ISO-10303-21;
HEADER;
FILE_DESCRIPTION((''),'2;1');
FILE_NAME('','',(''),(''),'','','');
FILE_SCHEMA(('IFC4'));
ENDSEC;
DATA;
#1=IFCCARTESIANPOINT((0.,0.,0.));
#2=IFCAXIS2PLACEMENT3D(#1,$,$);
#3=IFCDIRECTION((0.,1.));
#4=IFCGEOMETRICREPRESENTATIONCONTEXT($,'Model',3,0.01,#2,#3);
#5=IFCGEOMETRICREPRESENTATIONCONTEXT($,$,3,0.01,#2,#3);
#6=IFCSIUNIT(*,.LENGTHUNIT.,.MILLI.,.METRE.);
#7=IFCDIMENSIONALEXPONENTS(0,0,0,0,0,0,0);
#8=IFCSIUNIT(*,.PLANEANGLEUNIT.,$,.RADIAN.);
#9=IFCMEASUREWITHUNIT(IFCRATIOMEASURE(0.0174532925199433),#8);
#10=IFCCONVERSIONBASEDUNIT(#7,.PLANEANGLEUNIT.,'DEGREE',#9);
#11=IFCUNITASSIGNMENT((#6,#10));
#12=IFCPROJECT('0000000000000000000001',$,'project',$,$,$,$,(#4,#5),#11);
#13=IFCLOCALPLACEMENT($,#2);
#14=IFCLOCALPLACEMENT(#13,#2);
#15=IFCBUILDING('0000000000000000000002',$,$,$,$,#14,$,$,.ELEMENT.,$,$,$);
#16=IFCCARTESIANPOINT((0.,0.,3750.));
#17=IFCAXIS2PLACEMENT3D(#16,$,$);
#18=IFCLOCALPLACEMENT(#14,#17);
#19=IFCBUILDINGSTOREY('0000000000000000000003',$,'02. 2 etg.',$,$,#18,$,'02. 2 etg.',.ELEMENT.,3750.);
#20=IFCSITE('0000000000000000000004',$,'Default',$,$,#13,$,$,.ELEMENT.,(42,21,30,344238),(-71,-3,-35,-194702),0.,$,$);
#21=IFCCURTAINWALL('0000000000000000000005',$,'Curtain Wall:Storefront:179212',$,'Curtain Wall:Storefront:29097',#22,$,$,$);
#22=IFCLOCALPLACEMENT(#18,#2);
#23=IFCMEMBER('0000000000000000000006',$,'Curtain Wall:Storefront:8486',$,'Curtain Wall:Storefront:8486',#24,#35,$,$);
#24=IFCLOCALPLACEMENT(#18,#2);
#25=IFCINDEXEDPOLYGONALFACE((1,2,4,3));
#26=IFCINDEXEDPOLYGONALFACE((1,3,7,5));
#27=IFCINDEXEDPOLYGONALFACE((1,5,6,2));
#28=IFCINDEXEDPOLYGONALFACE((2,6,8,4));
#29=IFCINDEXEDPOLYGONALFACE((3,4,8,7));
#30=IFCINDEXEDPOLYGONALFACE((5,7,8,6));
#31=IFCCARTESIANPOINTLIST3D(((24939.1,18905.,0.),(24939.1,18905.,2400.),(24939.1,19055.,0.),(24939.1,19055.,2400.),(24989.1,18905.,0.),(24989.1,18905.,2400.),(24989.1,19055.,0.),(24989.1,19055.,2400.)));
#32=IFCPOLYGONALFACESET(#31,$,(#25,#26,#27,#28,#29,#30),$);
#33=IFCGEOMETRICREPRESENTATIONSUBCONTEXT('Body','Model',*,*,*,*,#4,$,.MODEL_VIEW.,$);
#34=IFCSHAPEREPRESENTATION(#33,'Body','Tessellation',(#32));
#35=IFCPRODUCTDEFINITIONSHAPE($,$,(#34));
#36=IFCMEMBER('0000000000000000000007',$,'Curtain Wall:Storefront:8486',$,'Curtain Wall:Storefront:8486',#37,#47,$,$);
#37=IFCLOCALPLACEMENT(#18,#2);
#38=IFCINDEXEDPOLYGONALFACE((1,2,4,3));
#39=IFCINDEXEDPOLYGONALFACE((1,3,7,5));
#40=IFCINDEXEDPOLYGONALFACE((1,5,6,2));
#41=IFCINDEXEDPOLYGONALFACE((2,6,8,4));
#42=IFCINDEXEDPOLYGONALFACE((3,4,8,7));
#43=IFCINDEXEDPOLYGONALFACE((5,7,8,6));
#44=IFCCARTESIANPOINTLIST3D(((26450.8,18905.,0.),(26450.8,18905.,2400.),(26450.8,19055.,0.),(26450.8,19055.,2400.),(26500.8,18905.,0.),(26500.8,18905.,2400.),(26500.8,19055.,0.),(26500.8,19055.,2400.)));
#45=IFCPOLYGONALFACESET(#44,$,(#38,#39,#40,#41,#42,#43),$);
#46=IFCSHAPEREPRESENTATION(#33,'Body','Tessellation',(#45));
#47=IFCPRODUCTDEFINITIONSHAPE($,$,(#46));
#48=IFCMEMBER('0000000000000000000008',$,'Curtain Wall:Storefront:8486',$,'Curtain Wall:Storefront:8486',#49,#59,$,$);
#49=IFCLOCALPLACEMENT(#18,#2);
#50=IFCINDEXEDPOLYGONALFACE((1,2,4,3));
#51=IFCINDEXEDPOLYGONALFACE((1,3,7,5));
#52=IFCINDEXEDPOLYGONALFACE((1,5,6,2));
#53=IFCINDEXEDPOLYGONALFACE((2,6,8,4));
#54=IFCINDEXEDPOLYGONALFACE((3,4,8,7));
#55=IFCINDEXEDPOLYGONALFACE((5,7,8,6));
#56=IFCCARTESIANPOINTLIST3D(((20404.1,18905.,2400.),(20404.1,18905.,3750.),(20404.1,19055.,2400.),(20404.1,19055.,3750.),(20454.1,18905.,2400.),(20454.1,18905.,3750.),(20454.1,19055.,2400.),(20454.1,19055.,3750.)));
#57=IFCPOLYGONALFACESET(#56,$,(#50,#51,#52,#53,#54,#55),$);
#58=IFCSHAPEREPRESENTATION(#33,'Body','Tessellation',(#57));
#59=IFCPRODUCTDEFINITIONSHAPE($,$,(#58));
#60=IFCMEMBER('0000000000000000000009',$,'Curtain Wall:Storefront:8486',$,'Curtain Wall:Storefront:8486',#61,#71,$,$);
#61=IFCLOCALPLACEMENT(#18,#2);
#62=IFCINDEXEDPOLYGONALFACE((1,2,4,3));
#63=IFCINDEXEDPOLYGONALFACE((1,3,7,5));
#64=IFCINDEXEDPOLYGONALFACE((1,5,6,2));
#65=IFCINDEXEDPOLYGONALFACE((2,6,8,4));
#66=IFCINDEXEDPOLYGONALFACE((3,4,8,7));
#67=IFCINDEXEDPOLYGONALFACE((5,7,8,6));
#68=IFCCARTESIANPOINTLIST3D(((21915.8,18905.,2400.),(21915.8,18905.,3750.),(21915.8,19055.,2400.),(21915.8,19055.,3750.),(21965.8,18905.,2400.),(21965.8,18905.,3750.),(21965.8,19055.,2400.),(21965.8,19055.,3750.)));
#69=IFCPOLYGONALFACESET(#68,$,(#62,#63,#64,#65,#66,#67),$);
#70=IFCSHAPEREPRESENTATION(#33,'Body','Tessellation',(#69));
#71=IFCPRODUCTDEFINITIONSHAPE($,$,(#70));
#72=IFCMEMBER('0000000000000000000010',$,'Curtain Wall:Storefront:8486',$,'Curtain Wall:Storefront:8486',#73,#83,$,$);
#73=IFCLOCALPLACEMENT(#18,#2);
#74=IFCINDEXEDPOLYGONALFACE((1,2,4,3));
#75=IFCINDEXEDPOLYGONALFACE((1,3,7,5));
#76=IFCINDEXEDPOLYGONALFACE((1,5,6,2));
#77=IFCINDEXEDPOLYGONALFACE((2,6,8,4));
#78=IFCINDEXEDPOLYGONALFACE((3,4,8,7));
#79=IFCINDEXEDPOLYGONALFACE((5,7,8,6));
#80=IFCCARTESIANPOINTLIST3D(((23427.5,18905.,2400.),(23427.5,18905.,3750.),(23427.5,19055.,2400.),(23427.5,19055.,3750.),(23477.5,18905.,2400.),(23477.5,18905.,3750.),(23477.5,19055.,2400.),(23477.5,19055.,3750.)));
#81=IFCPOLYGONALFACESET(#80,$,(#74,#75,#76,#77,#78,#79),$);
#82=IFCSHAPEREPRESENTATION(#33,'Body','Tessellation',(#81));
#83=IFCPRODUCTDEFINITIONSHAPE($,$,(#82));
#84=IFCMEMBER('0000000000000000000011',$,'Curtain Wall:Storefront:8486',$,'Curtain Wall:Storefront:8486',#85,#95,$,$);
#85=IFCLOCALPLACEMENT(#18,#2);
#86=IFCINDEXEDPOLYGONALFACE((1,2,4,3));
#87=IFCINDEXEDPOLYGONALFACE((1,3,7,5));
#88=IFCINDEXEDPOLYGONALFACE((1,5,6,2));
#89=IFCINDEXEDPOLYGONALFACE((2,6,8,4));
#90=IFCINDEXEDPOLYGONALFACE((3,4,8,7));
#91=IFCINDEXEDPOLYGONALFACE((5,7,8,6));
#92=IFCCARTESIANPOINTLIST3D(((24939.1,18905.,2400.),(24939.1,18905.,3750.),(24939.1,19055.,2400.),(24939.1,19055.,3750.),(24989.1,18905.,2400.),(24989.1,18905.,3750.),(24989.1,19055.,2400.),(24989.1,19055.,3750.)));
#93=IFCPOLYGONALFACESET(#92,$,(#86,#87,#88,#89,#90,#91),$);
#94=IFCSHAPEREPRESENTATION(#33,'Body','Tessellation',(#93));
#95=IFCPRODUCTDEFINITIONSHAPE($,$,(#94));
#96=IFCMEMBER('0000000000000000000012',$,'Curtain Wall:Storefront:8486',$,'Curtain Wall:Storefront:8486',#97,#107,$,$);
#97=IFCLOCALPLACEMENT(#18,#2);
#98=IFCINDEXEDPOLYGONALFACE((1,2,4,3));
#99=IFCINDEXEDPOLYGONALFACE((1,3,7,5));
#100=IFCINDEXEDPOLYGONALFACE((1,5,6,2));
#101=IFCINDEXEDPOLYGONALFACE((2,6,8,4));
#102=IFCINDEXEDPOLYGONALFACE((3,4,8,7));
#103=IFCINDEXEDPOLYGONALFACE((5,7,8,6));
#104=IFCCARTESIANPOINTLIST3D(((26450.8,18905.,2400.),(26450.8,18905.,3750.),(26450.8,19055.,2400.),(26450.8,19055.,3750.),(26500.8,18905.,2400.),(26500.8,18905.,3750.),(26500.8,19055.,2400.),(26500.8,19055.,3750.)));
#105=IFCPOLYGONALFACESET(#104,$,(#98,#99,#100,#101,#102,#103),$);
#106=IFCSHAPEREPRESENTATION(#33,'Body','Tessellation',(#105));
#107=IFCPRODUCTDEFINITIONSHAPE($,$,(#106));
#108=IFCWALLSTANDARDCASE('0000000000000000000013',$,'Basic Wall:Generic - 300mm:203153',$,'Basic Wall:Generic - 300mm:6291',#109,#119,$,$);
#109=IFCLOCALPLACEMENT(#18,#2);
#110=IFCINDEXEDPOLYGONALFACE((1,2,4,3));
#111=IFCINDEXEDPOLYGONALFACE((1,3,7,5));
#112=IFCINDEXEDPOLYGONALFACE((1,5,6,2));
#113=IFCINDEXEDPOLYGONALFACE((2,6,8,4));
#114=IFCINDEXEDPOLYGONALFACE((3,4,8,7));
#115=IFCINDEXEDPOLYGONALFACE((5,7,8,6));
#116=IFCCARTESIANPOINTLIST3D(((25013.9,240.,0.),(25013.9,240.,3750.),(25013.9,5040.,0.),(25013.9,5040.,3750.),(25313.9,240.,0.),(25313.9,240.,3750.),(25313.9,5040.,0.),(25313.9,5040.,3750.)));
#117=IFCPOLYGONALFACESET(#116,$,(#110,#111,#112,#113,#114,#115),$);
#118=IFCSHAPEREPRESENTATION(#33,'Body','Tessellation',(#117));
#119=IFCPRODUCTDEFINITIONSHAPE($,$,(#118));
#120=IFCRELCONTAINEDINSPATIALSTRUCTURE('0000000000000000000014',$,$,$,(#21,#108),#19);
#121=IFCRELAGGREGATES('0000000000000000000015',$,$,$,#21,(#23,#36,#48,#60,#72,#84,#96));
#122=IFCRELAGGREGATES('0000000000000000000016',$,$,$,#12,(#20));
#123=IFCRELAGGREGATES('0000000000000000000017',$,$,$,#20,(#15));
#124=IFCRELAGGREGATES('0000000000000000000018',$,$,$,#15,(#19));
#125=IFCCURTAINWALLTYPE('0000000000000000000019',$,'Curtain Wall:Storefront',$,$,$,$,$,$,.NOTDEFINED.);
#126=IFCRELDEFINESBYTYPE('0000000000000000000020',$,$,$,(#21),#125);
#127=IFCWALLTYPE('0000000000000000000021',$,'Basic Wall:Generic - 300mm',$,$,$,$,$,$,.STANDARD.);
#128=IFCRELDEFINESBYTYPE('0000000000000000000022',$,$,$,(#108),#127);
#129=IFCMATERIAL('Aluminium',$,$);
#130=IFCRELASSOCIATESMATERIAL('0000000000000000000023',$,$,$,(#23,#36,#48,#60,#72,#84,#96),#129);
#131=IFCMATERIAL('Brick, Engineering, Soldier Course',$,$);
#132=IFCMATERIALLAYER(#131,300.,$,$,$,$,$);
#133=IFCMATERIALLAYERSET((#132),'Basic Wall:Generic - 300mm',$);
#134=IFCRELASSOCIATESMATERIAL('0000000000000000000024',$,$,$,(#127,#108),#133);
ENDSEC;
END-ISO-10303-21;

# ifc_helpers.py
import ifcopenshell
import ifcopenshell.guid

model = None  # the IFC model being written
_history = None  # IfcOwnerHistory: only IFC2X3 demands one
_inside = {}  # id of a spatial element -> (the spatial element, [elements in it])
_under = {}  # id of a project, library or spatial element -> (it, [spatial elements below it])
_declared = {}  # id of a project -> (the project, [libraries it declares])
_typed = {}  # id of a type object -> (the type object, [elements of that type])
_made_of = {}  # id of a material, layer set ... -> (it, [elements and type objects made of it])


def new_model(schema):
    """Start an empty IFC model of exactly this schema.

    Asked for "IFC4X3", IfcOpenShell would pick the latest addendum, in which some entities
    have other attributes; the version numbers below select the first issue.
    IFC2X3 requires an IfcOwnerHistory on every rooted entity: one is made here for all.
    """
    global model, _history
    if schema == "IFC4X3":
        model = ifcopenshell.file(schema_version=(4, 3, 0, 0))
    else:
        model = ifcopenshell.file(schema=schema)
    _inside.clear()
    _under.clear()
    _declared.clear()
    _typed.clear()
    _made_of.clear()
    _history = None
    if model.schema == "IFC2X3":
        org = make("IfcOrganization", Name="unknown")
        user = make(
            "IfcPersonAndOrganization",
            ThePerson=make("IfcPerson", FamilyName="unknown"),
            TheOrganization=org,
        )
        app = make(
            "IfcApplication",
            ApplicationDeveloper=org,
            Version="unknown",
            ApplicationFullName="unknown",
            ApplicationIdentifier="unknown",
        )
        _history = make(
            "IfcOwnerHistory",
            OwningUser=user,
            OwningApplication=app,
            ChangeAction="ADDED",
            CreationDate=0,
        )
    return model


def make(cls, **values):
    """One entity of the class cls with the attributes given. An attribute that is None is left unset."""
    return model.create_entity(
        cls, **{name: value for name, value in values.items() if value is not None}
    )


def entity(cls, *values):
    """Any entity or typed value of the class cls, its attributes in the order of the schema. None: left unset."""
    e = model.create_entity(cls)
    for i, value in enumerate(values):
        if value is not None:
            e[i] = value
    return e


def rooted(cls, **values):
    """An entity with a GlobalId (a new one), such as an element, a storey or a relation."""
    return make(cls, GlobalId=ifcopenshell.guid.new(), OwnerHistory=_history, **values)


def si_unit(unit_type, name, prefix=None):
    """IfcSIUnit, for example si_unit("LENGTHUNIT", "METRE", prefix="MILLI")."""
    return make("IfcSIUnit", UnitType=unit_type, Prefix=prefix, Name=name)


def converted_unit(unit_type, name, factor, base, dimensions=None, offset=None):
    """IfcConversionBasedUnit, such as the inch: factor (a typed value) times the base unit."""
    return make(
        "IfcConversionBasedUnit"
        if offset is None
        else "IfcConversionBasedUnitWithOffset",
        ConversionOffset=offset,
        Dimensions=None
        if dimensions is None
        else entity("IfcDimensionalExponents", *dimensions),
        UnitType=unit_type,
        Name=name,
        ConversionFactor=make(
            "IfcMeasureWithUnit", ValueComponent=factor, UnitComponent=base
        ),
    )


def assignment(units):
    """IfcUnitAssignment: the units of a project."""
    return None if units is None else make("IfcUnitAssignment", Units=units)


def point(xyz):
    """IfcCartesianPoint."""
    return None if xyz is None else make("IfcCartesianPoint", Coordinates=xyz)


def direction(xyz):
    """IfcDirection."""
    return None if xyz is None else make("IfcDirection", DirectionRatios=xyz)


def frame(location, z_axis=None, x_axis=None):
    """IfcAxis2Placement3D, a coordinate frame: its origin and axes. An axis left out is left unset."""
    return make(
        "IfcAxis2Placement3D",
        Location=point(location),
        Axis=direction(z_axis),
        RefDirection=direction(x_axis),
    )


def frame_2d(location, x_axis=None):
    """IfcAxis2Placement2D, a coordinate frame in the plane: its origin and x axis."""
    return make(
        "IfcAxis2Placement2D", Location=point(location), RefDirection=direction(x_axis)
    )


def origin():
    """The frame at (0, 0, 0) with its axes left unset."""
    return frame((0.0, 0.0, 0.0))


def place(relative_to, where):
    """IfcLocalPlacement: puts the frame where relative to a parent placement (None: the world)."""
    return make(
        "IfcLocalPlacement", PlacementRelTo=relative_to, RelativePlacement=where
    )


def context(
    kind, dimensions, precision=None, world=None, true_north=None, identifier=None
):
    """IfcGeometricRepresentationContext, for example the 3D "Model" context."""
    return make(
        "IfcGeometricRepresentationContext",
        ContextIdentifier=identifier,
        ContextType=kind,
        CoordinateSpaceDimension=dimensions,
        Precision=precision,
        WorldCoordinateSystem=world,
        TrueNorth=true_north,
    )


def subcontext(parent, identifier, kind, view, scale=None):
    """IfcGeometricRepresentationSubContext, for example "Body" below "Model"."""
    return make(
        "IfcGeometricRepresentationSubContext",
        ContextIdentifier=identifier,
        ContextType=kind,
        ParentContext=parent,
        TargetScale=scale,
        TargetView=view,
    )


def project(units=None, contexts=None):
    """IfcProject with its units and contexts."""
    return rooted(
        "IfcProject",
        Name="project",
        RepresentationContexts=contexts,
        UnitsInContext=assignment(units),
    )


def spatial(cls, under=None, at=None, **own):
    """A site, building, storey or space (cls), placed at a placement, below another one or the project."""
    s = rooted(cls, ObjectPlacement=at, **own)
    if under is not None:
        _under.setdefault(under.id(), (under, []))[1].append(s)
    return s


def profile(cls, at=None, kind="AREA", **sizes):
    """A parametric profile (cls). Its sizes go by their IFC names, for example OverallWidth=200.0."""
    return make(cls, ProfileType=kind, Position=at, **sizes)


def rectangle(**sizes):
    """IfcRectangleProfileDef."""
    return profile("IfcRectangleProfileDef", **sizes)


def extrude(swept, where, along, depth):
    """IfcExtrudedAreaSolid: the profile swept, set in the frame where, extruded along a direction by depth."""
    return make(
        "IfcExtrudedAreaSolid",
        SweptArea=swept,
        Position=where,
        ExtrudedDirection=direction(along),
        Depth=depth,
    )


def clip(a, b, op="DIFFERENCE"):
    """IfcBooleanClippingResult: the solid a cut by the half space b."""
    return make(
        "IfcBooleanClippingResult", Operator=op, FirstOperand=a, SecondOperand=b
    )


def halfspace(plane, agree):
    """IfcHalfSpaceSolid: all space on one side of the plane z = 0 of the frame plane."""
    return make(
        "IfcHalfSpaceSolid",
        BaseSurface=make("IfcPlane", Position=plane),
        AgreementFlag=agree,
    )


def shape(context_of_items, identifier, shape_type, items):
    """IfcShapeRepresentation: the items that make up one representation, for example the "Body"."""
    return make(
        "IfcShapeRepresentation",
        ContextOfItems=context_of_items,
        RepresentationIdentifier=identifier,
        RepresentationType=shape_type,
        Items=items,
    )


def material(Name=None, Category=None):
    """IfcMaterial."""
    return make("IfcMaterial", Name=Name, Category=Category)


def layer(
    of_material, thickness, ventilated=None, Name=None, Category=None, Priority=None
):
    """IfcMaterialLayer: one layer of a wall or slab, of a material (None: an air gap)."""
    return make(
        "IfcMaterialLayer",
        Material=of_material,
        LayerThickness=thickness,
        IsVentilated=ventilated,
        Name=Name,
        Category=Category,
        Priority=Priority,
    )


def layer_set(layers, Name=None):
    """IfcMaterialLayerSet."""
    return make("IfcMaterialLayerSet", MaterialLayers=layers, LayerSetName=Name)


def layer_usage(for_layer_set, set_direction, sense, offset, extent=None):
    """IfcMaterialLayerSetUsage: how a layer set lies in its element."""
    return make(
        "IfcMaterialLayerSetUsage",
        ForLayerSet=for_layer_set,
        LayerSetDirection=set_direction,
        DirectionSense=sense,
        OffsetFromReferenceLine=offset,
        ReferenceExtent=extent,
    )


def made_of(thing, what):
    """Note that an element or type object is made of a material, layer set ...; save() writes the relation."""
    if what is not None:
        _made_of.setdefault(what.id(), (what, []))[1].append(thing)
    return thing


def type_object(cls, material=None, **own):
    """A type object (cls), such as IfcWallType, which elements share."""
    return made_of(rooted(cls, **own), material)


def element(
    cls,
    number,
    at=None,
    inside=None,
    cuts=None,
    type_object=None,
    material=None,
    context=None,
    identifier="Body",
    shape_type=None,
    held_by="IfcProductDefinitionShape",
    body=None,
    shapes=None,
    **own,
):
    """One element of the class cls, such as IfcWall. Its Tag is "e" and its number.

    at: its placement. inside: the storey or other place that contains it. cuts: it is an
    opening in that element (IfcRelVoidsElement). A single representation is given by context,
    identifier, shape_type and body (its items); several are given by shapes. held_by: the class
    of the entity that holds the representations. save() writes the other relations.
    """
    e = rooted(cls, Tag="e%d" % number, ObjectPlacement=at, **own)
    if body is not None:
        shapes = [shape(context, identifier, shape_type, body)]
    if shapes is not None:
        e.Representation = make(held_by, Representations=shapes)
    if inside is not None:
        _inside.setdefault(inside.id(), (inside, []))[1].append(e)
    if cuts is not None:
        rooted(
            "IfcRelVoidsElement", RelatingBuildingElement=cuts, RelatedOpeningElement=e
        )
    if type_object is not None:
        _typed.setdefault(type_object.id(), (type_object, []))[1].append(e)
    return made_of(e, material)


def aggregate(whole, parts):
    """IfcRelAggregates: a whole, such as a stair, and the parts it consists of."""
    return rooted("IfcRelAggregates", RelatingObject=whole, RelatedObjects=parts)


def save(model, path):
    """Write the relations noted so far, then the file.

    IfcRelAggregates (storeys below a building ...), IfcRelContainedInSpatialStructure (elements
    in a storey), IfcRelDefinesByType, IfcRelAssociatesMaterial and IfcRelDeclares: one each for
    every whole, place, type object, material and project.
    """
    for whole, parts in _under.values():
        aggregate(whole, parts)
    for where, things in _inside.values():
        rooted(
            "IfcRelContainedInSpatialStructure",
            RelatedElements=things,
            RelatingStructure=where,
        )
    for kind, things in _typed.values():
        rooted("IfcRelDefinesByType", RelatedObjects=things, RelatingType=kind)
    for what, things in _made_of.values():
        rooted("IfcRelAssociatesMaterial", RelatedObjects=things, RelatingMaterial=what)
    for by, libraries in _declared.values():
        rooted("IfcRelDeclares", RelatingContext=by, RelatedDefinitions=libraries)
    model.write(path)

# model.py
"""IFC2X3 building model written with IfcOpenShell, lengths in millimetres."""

from ifc_helpers import new_model, entity, si_unit, converted_unit, direction, frame, frame_2d, origin, place, context, subcontext, project, spatial, rectangle, extrude, clip, halfspace, material, layer, layer_set, layer_usage, type_object, element, aggregate, save


model = new_model("IFC2X3")

# Units and contexts
model_context = context("Model", 3, precision=0.01, world=origin(), true_north=direction((0.0, 1.0)))
context_of_model = context(None, 3, precision=0.01, world=origin(), true_north=direction((0.0, 1.0)))
body_context = subcontext(model_context, "Body", "Model", "MODEL_VIEW")
ifc_project = project(units=[si_unit("LENGTHUNIT", "METRE", prefix="MILLI"), converted_unit("PLANEANGLEUNIT", "DEGREE", entity("IfcRatioMeasure", 0.0174532925199433), si_unit("PLANEANGLEUNIT", "RADIAN"), dimensions=[0, 0, 0, 0, 0, 0, 0])], contexts=[model_context, context_of_model])

# Site, building, storey
site_placement = place(None, origin())
site = spatial("IfcSite", under=ifc_project, at=site_placement, Name="Default", CompositionType="ELEMENT", RefLatitude=(42, 21, 30, 344238), RefLongitude=(-71, -3, -35, -194702), RefElevation=0.0)
building_placement = place(site_placement, origin())
building = spatial("IfcBuilding", under=site, at=building_placement, CompositionType="ELEMENT")
storey_placement = place(building_placement, frame((0.0, 0.0, 3750.0)))
storey = spatial("IfcBuildingStorey", under=building, at=storey_placement, Name="02. 2 etg.", LongName="02. 2 etg.", CompositionType="ELEMENT", Elevation=3750.0)

# Curtain wall, members
curtain_wall_type = type_object("IfcCurtainWallType", Name="Curtain Wall:Storefront", PredefinedType="NOTDEFINED")
curtain_wall_placement = place(storey_placement, frame((0.0, 0.0, -3750.0)))
curtain_wall = element("IfcCurtainWall", 1, at=curtain_wall_placement, inside=storey, type_object=curtain_wall_type, Name="Curtain Wall:Storefront:179212", ObjectType="Curtain Wall:Storefront:29097")
ifc_material_1 = material(Name="Aluminium")
member_1_placement = place(curtain_wall_placement, frame((24939.1, 18905.0, 3750.0)))
member_1 = element("IfcMember", 2, at=member_1_placement, material=ifc_material_1, Name="Curtain Wall:Storefront:8486", ObjectType="Curtain Wall:Storefront:8486", context=body_context, shape_type="SweptSolid", body=[
    extrude(rectangle(XDim=150.0, YDim=50.0, at=frame_2d((0.0, 0.0), x_axis=(1.0, 0.0))), frame((25.0, 75.0, 0.0), z_axis=(0.0, 0.0, 1.0), x_axis=(0.0, 1.0, 0.0)), (0.0, 0.0, 1.0), 2400.0),
])
member_2_placement = place(curtain_wall_placement, frame((26450.8, 18905.0, 3750.0)))
member_2 = element("IfcMember", 3, at=member_2_placement, material=ifc_material_1, Name="Curtain Wall:Storefront:8486", ObjectType="Curtain Wall:Storefront:8486", context=body_context, shape_type="SweptSolid", body=[
    extrude(rectangle(XDim=150.0, YDim=50.0, at=frame_2d((0.0, 0.0), x_axis=(1.0, 0.0))), frame((25.0, 75.0, 0.0), z_axis=(0.0, 0.0, 1.0), x_axis=(0.0, 1.0, 0.0)), (0.0, 0.0, 1.0), 2400.0),
])
member_3_placement = place(curtain_wall_placement, frame((20404.1, 18905.0, 6150.0)))
member_3 = element("IfcMember", 4, at=member_3_placement, material=ifc_material_1, Name="Curtain Wall:Storefront:8486", ObjectType="Curtain Wall:Storefront:8486", context=body_context, shape_type="SweptSolid", body=[
    extrude(rectangle(XDim=150.0, YDim=50.0, at=frame_2d((0.0, 0.0), x_axis=(1.0, 0.0))), frame((25.0, 75.0, 0.0), z_axis=(0.0, 0.0, 1.0), x_axis=(0.0, 1.0, 0.0)), (0.0, 0.0, 1.0), 1350.0),
])
member_4_placement = place(curtain_wall_placement, frame((21915.8, 18905.0, 6150.0)))
member_4 = element("IfcMember", 5, at=member_4_placement, material=ifc_material_1, Name="Curtain Wall:Storefront:8486", ObjectType="Curtain Wall:Storefront:8486", context=body_context, shape_type="SweptSolid", body=[
    extrude(rectangle(XDim=150.0, YDim=50.0, at=frame_2d((0.0, 0.0), x_axis=(1.0, 0.0))), frame((25.0, 75.0, 0.0), z_axis=(0.0, 0.0, 1.0), x_axis=(0.0, 1.0, 0.0)), (0.0, 0.0, 1.0), 1350.0),
])
member_5_placement = place(curtain_wall_placement, frame((23427.5, 18905.0, 6150.0)))
member_5 = element("IfcMember", 6, at=member_5_placement, material=ifc_material_1, Name="Curtain Wall:Storefront:8486", ObjectType="Curtain Wall:Storefront:8486", context=body_context, shape_type="SweptSolid", body=[
    extrude(rectangle(XDim=150.0, YDim=50.0, at=frame_2d((0.0, 0.0), x_axis=(1.0, 0.0))), frame((25.0, 75.0, 0.0), z_axis=(0.0, 0.0, 1.0), x_axis=(0.0, 1.0, 0.0)), (0.0, 0.0, 1.0), 1350.0),
])
member_6_placement = place(curtain_wall_placement, frame((24939.1, 18905.0, 6150.0)))
member_6 = element("IfcMember", 7, at=member_6_placement, material=ifc_material_1, Name="Curtain Wall:Storefront:8486", ObjectType="Curtain Wall:Storefront:8486", context=body_context, shape_type="SweptSolid", body=[
    extrude(rectangle(XDim=150.0, YDim=50.0, at=frame_2d((0.0, 0.0), x_axis=(1.0, 0.0))), frame((25.0, 75.0, 0.0), z_axis=(0.0, 0.0, 1.0), x_axis=(0.0, 1.0, 0.0)), (0.0, 0.0, 1.0), 1350.0),
])
member_7_placement = place(curtain_wall_placement, frame((26450.8, 18905.0, 6150.0)))
member_7 = element("IfcMember", 8, at=member_7_placement, material=ifc_material_1, Name="Curtain Wall:Storefront:8486", ObjectType="Curtain Wall:Storefront:8486", context=body_context, shape_type="SweptSolid", body=[
    extrude(rectangle(XDim=150.0, YDim=50.0, at=frame_2d((0.0, 0.0), x_axis=(1.0, 0.0))), frame((25.0, 75.0, 0.0), z_axis=(0.0, 0.0, 1.0), x_axis=(0.0, 1.0, 0.0)), (0.0, 0.0, 1.0), 1350.0),
])
aggregate(curtain_wall, [member_1, member_2, member_3, member_4, member_5, member_6, member_7])

# Wall
ifc_material_2 = material(Name="Brick, Engineering, Soldier Course")
ifc_layer = layer(ifc_material_2, 300.0)
ifc_layer_set = layer_set([ifc_layer], Name="Basic Wall:Generic - 300mm")
ifc_layer_usage = layer_usage(ifc_layer_set, "AXIS2", "NEGATIVE", 150.0)
wall_type = type_object("IfcWallType", Name="Basic Wall:Generic - 300mm", PredefinedType="STANDARD", material=ifc_layer_set)
wall_placement = place(storey_placement, frame((25163.9, 5040.0, 0.0), z_axis=(0.0, 0.0, 1.0), x_axis=(0.0, -1.0, 0.0)))
element("IfcWallStandardCase", 9, at=wall_placement, inside=storey, type_object=wall_type, material=ifc_layer_usage, Name="Basic Wall:Generic - 300mm:203153", ObjectType="Basic Wall:Generic - 300mm:6291", context=body_context, shape_type="Clipping", body=[
    clip(extrude(rectangle(XDim=4800.0, YDim=300.0, at=frame_2d((2400.0, 0.0), x_axis=(-1.0, 0.0))), origin(), (0.0, 0.0, 1.0), 3750.0), halfspace(origin(), True)),
])

save(model, "model.ifc")
